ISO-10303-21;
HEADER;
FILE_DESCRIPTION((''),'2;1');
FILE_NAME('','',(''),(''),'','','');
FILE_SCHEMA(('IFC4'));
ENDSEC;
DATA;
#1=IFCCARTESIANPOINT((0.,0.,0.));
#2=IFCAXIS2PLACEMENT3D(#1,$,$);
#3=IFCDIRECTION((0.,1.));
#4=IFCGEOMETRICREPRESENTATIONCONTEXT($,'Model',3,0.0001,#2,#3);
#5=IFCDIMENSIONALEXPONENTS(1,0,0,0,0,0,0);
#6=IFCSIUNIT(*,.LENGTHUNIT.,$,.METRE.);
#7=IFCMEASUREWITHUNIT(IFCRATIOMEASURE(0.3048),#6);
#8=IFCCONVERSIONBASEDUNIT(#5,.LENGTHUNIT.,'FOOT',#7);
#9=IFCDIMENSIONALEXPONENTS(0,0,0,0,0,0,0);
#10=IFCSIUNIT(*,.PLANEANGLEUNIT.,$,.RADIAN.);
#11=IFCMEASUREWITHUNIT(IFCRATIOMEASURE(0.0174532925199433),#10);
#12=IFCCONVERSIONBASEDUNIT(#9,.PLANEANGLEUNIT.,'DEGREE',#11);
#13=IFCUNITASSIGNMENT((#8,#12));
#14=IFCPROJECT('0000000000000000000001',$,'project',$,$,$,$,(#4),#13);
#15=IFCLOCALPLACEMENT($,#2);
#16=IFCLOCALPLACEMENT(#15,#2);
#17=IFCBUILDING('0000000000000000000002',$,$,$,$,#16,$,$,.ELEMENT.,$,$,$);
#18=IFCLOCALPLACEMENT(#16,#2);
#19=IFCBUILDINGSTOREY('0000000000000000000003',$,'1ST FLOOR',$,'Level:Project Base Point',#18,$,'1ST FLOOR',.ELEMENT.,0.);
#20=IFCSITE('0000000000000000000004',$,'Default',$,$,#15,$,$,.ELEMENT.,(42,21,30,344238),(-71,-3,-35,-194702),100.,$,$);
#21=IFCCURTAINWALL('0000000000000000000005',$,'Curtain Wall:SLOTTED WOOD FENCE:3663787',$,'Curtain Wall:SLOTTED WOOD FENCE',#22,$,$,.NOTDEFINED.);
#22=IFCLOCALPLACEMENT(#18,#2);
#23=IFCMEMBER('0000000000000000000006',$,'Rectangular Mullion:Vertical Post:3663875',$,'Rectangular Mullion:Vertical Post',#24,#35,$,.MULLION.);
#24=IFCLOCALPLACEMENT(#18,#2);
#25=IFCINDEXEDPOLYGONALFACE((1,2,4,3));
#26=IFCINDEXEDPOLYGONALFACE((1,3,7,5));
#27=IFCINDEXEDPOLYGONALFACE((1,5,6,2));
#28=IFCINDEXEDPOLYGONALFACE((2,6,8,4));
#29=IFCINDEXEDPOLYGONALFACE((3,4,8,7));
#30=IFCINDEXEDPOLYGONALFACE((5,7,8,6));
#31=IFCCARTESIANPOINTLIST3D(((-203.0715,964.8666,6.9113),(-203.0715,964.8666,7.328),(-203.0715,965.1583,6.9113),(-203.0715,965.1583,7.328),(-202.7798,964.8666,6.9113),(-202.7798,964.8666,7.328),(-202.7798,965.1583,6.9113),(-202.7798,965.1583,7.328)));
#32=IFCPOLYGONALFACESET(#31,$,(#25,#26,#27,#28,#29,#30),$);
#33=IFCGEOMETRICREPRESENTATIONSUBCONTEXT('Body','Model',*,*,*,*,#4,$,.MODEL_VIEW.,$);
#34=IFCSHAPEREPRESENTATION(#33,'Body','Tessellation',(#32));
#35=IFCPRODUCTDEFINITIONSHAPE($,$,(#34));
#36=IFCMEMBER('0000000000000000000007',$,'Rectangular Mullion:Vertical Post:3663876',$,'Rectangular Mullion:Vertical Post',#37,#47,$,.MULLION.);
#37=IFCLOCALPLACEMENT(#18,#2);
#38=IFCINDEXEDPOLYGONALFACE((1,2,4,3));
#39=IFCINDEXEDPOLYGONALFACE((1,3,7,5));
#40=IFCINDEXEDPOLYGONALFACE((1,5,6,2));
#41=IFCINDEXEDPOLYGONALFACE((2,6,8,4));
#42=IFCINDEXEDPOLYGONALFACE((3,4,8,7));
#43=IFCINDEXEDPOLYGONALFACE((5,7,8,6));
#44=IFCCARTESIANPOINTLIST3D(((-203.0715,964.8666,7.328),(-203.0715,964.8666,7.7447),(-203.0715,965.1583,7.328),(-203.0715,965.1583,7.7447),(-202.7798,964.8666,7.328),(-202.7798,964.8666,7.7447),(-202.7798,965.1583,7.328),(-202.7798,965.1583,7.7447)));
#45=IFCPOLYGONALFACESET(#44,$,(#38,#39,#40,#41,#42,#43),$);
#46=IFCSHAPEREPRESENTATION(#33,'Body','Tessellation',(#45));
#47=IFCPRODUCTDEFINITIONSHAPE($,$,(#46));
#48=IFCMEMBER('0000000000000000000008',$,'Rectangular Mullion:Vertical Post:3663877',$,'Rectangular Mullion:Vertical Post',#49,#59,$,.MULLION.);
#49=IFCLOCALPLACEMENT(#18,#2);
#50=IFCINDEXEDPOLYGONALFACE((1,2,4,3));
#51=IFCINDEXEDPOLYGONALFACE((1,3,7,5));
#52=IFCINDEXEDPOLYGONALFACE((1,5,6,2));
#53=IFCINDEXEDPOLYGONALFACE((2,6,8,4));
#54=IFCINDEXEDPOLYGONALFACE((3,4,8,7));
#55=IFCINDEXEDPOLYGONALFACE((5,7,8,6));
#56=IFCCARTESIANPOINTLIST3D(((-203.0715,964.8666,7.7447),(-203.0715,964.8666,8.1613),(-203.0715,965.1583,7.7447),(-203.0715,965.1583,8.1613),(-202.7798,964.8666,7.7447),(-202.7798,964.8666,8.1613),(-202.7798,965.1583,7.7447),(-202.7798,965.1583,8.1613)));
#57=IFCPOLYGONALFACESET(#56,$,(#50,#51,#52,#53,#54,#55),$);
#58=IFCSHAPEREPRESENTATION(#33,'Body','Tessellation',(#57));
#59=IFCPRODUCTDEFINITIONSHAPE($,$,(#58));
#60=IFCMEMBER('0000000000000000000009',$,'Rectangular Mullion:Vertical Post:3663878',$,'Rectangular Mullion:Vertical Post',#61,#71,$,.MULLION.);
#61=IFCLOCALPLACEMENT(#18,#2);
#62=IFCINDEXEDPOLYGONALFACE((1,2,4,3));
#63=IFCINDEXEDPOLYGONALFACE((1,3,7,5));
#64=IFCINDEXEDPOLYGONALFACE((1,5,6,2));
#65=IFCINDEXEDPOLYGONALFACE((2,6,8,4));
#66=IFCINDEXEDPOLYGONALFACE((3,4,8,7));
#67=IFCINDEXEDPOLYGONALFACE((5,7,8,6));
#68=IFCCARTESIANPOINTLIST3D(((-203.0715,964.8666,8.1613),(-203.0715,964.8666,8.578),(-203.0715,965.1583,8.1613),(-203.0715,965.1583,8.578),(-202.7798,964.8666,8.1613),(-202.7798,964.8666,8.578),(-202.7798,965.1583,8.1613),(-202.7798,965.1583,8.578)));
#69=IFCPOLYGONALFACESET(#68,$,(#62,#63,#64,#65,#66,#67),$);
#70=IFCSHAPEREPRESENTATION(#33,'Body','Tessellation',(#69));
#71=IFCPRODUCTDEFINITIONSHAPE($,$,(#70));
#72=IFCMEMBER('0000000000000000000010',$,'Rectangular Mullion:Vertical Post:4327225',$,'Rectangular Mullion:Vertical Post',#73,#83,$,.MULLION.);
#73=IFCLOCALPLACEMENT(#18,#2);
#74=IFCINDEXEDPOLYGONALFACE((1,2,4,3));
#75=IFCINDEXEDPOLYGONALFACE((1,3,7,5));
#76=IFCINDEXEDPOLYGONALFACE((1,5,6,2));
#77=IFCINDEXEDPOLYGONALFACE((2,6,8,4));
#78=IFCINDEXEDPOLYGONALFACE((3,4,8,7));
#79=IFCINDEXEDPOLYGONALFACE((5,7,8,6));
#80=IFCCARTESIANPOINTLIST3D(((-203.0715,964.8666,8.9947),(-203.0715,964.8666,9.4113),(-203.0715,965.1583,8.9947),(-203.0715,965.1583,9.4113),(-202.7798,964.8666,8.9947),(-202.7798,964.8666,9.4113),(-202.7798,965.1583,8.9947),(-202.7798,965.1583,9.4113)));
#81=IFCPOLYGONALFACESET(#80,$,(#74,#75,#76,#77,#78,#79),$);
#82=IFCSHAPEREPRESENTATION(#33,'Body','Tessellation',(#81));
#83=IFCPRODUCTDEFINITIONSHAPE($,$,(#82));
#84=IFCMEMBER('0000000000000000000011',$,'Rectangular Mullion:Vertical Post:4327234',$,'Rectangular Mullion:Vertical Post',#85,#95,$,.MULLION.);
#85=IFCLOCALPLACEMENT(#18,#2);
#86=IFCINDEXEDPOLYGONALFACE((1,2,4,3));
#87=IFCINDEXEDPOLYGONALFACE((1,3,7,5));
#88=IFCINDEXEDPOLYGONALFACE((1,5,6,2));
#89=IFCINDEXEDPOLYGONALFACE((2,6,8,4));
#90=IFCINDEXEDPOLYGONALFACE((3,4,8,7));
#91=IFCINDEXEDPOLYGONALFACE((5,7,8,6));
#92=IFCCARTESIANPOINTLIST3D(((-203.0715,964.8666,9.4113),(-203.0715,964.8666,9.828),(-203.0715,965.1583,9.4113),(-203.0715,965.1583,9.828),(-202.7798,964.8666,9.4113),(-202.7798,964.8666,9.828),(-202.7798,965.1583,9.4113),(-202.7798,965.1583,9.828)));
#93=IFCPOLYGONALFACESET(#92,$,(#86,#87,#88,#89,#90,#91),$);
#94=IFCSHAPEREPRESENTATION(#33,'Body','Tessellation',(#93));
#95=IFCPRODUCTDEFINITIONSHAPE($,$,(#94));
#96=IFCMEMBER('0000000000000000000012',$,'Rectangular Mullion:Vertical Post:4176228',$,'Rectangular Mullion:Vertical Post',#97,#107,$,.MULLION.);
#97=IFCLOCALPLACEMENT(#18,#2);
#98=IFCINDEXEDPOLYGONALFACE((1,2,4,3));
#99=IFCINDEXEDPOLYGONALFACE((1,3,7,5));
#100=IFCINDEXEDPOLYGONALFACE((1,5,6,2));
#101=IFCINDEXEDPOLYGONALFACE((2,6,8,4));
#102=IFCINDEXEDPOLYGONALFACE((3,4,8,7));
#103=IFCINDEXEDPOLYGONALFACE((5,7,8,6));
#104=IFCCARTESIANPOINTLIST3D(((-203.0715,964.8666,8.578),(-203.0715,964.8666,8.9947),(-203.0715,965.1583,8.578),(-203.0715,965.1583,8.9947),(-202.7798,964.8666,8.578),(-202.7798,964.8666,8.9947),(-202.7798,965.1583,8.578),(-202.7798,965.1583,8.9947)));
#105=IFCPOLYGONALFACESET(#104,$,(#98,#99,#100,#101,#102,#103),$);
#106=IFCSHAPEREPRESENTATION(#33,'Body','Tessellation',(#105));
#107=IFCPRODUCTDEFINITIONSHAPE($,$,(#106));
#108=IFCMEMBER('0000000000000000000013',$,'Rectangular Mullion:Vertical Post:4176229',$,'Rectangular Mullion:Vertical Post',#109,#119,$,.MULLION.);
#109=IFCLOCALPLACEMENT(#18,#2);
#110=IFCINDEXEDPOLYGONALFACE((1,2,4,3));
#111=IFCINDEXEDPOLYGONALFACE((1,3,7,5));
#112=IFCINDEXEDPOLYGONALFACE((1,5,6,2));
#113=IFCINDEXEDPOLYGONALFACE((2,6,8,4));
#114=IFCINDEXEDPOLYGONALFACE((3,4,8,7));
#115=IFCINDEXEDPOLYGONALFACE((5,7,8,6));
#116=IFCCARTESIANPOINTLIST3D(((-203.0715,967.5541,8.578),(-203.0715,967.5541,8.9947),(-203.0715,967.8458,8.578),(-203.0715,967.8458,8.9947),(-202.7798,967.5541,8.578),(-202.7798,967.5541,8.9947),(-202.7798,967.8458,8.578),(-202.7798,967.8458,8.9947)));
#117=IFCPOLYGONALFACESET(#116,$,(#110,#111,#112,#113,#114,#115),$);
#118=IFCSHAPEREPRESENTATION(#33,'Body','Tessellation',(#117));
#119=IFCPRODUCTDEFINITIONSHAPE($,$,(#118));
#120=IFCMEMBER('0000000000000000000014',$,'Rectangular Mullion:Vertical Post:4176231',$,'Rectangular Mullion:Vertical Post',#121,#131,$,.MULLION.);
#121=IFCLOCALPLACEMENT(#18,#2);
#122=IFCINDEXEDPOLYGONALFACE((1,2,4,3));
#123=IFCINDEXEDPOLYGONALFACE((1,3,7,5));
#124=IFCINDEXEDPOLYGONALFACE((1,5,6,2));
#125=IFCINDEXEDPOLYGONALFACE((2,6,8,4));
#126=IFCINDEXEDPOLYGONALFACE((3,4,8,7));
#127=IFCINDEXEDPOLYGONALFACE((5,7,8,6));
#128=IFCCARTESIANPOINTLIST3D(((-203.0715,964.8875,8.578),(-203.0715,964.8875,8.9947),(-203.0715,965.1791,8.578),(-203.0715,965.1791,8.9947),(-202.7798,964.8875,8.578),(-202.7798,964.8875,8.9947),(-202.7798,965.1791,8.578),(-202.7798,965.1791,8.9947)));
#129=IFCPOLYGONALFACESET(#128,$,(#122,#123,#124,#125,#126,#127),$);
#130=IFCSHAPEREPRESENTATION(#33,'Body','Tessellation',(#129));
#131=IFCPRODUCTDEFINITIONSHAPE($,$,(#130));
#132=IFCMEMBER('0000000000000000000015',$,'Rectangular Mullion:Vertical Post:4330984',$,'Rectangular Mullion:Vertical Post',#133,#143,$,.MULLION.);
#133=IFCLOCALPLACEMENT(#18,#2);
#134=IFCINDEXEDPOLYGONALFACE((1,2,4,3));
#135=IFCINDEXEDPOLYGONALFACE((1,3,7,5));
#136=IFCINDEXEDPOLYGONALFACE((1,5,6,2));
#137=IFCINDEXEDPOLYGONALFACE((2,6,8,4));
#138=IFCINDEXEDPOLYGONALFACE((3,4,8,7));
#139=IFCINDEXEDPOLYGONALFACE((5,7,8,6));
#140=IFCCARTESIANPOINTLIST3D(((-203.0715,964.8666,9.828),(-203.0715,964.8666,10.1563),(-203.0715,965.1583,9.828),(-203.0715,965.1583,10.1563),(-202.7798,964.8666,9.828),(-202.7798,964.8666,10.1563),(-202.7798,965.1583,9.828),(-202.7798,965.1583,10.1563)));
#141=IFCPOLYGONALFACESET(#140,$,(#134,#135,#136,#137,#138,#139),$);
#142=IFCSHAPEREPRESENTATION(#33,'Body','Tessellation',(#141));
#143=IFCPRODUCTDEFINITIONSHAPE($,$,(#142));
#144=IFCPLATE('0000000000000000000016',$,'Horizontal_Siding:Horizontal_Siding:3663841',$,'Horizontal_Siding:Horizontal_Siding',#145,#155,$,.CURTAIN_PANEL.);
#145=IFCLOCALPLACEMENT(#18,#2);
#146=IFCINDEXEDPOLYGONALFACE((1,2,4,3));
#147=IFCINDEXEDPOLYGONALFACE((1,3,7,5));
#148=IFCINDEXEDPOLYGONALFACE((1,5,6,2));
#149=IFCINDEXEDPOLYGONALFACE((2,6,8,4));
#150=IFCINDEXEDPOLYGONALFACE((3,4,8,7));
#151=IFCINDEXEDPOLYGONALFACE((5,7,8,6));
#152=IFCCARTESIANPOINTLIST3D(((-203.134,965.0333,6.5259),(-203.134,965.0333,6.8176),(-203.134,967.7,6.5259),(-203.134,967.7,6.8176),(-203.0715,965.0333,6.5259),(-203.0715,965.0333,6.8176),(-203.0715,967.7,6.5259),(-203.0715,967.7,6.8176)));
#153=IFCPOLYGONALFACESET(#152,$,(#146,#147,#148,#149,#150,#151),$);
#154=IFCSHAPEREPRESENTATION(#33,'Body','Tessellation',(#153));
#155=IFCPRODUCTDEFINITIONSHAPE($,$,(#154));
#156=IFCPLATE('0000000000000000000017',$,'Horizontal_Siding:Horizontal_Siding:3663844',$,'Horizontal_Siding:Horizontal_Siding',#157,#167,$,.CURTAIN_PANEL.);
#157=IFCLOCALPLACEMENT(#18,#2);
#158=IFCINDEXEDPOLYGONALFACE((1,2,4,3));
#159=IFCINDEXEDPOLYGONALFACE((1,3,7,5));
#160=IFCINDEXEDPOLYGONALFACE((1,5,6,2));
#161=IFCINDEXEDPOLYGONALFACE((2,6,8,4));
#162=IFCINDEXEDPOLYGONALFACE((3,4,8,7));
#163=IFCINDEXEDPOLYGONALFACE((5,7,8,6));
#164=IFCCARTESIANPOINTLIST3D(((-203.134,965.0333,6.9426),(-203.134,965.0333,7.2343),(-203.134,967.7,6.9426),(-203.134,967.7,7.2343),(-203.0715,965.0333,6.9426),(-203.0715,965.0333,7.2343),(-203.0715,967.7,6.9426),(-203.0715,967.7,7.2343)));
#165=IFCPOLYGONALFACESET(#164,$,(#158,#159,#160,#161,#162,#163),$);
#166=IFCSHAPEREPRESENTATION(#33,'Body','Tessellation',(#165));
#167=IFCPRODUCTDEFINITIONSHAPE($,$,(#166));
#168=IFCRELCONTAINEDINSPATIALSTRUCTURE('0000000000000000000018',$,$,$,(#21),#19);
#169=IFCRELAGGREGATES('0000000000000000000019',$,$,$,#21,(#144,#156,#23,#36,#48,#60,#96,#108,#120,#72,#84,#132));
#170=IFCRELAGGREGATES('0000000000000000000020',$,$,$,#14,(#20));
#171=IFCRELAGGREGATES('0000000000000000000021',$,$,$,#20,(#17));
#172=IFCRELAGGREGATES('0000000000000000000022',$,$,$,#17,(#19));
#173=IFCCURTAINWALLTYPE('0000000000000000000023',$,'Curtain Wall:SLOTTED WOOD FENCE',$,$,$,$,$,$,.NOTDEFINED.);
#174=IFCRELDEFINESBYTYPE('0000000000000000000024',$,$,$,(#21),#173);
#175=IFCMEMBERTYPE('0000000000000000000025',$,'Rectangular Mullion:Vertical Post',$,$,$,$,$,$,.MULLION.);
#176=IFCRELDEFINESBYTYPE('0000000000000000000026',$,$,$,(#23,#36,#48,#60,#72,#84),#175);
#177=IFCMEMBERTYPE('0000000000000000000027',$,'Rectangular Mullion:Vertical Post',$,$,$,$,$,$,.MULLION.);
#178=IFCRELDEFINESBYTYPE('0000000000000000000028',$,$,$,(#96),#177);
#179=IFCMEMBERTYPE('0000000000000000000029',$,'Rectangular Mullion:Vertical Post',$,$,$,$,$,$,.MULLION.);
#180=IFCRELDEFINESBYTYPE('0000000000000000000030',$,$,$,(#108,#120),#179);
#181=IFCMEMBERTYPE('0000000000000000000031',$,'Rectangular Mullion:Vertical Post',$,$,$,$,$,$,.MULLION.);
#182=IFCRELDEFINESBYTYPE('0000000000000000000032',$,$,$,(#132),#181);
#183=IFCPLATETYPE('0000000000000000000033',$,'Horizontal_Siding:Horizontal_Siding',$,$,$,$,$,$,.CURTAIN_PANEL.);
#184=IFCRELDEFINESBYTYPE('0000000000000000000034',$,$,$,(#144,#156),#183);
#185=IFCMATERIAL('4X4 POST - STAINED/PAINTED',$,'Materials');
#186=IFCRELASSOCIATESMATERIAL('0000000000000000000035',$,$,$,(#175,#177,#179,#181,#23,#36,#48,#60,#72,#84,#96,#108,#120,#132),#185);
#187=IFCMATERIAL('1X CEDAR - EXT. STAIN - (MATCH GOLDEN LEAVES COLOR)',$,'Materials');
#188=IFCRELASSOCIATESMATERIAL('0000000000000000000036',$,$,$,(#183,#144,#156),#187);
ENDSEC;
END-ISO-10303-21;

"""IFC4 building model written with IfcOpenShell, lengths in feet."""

from ifc_helpers import new_model, entity, si_unit, converted_unit, direction, frame, origin, origin_2d_with_axis, place, context, subcontext, project, spatial, rectangle, extrude, source, transform, mapped, material, material_profile, profile_set, profile_usage, type_object, type_shapes, element, aggregate, save


model = new_model("IFC4")

# Units and contexts
model_context = context("Model", 3, precision=0.0001, world=origin(), true_north=direction((0.0, 1.0)))
body_context = subcontext(model_context, "Body", "Model", "MODEL_VIEW")
ifc_project = project(units=[converted_unit("LENGTHUNIT", "FOOT", entity("IfcRatioMeasure", 0.3048), si_unit("LENGTHUNIT", "METRE"), dimensions=[1, 0, 0, 0, 0, 0, 0]), converted_unit("PLANEANGLEUNIT", "DEGREE", entity("IfcRatioMeasure", 0.0174532925199433), si_unit("PLANEANGLEUNIT", "RADIAN"), dimensions=[0, 0, 0, 0, 0, 0, 0])], contexts=[model_context])

# Site, building, storey
site_placement = place(None, origin())
site = spatial("IfcSite", under=ifc_project, at=site_placement, Name="Default", CompositionType="ELEMENT", RefLatitude=(42, 21, 30, 344238), RefLongitude=(-71, -3, -35, -194702), RefElevation=100.0)
building_placement = place(site_placement, origin())
building = spatial("IfcBuilding", under=site, at=building_placement, CompositionType="ELEMENT")
storey_placement = place(building_placement, origin())
storey = spatial("IfcBuildingStorey", under=building, at=storey_placement, Name="1ST FLOOR", ObjectType="Level:Project Base Point", LongName="1ST FLOOR", CompositionType="ELEMENT", Elevation=0.0)

# Curtain wall, members, plates
curtain_wall_type = type_object("IfcCurtainWallType", Name="Curtain Wall:SLOTTED WOOD FENCE", PredefinedType="NOTDEFINED")
curtain_wall_placement = place(storey_placement, origin())
curtain_wall = element("IfcCurtainWall", 1, at=curtain_wall_placement, inside=storey, type_object=curtain_wall_type, Name="Curtain Wall:SLOTTED WOOD FENCE:3663787", ObjectType="Curtain Wall:SLOTTED WOOD FENCE", PredefinedType="NOTDEFINED")
ifc_material_1 = material(Name="4X4 POST - STAINED/PAINTED", Category="Materials")
ifc_material_profile = material_profile(ifc_material_1, rectangle(XDim=0.2917, YDim=0.2917, at=origin_2d_with_axis()), Name="Vertical Post")
ifc_profile_set = profile_set([ifc_material_profile], Name="Vertical Post")
ifc_profile_usage_1 = profile_usage(ifc_profile_set)
member_type_1 = type_object("IfcMemberType", Name="Rectangular Mullion:Vertical Post", PredefinedType="MULLION", material=ifc_profile_set)
shared_shape_1 = source(origin(), body_context, "Body", "SweptSolid", [
    extrude(rectangle(XDim=0.2917, YDim=0.2917, at=origin_2d_with_axis()), frame((-0.1458, -0.2083, -0.4167), z_axis=(0.0, 0.0, 1.0), x_axis=(0.0, -1.0, 0.0)), (0.0, 0.0, 1.0), 0.4167),
])
type_shapes(member_type_1, [shared_shape_1])
member_1_placement = place(storey_placement, frame((-203.134, 964.8666, 6.9113), z_axis=(0.0, 0.0, -1.0), x_axis=(0.0, -1.0, 0.0)))
member_1 = element("IfcMember", 2, at=member_1_placement, type_object=member_type_1, material=ifc_profile_usage_1, Name="Rectangular Mullion:Vertical Post:3663875", ObjectType="Rectangular Mullion:Vertical Post", PredefinedType="MULLION", context=body_context, shape_type="MappedRepresentation", body=[
    mapped(shared_shape_1, transform((0.0, 0.0, 0.0), scale=1.0)),
])
ifc_profile_usage_2 = profile_usage(ifc_profile_set)
member_2_placement = place(storey_placement, frame((-203.134, 964.8666, 7.328), z_axis=(0.0, 0.0, -1.0), x_axis=(0.0, -1.0, 0.0)))
member_2 = element("IfcMember", 3, at=member_2_placement, type_object=member_type_1, material=ifc_profile_usage_2, Name="Rectangular Mullion:Vertical Post:3663876", ObjectType="Rectangular Mullion:Vertical Post", PredefinedType="MULLION", context=body_context, shape_type="MappedRepresentation", body=[
    mapped(shared_shape_1, transform((0.0, 0.0, 0.0), scale=1.0)),
])
ifc_profile_usage_3 = profile_usage(ifc_profile_set)
member_3_placement = place(storey_placement, frame((-203.134, 964.8666, 7.7447), z_axis=(0.0, 0.0, -1.0), x_axis=(0.0, -1.0, 0.0)))
member_3 = element("IfcMember", 4, at=member_3_placement, type_object=member_type_1, material=ifc_profile_usage_3, Name="Rectangular Mullion:Vertical Post:3663877", ObjectType="Rectangular Mullion:Vertical Post", PredefinedType="MULLION", context=body_context, shape_type="MappedRepresentation", body=[
    mapped(shared_shape_1, transform((0.0, 0.0, 0.0), scale=1.0)),
])
ifc_profile_usage_4 = profile_usage(ifc_profile_set)
member_4_placement = place(storey_placement, frame((-203.134, 964.8666, 8.1613), z_axis=(0.0, 0.0, -1.0), x_axis=(0.0, -1.0, 0.0)))
member_4 = element("IfcMember", 5, at=member_4_placement, type_object=member_type_1, material=ifc_profile_usage_4, Name="Rectangular Mullion:Vertical Post:3663878", ObjectType="Rectangular Mullion:Vertical Post", PredefinedType="MULLION", context=body_context, shape_type="MappedRepresentation", body=[
    mapped(shared_shape_1, transform((0.0, 0.0, 0.0), scale=1.0)),
])
ifc_profile_usage_5 = profile_usage(ifc_profile_set)
member_5_placement = place(storey_placement, frame((-203.134, 964.8666, 8.9947), z_axis=(0.0, 0.0, -1.0), x_axis=(0.0, -1.0, 0.0)))
member_5 = element("IfcMember", 6, at=member_5_placement, type_object=member_type_1, material=ifc_profile_usage_5, Name="Rectangular Mullion:Vertical Post:4327225", ObjectType="Rectangular Mullion:Vertical Post", PredefinedType="MULLION", context=body_context, shape_type="MappedRepresentation", body=[
    mapped(shared_shape_1, transform((0.0, 0.0, 0.0), scale=1.0)),
])
ifc_profile_usage_6 = profile_usage(ifc_profile_set)
member_6_placement = place(storey_placement, frame((-203.134, 964.8666, 9.4113), z_axis=(0.0, 0.0, -1.0), x_axis=(0.0, -1.0, 0.0)))
member_6 = element("IfcMember", 7, at=member_6_placement, type_object=member_type_1, material=ifc_profile_usage_6, Name="Rectangular Mullion:Vertical Post:4327234", ObjectType="Rectangular Mullion:Vertical Post", PredefinedType="MULLION", context=body_context, shape_type="MappedRepresentation", body=[
    mapped(shared_shape_1, transform((0.0, 0.0, 0.0), scale=1.0)),
])
ifc_profile_usage_7 = profile_usage(ifc_profile_set)
member_type_2 = type_object("IfcMemberType", Name="Rectangular Mullion:Vertical Post", PredefinedType="MULLION", material=ifc_profile_set)
shared_shape_2 = source(origin(), body_context, "Body", "SweptSolid", [
    extrude(rectangle(XDim=0.2917, YDim=0.2917, at=origin_2d_with_axis()), frame((-0.1458, -0.2083, -0.4167), z_axis=(0.0, 0.0, 1.0), x_axis=(0.0, -1.0, 0.0)), (0.0, 0.0, 1.0), 0.4167),
])
type_shapes(member_type_2, [shared_shape_2])
member_7_placement = place(storey_placement, frame((-203.134, 964.8666, 8.578), z_axis=(0.0, 0.0, -1.0), x_axis=(0.0, -1.0, 0.0)))
member_7 = element("IfcMember", 8, at=member_7_placement, type_object=member_type_2, material=ifc_profile_usage_7, Name="Rectangular Mullion:Vertical Post:4176228", ObjectType="Rectangular Mullion:Vertical Post", PredefinedType="MULLION", context=body_context, shape_type="MappedRepresentation", body=[
    mapped(shared_shape_2, transform((0.0, 0.0, 0.0), scale=1.0)),
])
ifc_profile_usage_8 = profile_usage(ifc_profile_set)
member_type_3 = type_object("IfcMemberType", Name="Rectangular Mullion:Vertical Post", PredefinedType="MULLION", material=ifc_profile_set)
shared_shape_3 = source(origin(), body_context, "Body", "SweptSolid", [
    extrude(rectangle(XDim=0.2917, YDim=0.2917, at=origin_2d_with_axis()), frame((0.0, -0.2083, -0.4167), z_axis=(0.0, 0.0, 1.0), x_axis=(0.0, -1.0, 0.0)), (0.0, 0.0, 1.0), 0.4167),
])
type_shapes(member_type_3, [shared_shape_3])
member_8_placement = place(storey_placement, frame((-203.134, 967.7, 8.578), z_axis=(0.0, 0.0, -1.0), x_axis=(0.0, -1.0, 0.0)))
member_8 = element("IfcMember", 9, at=member_8_placement, type_object=member_type_3, material=ifc_profile_usage_8, Name="Rectangular Mullion:Vertical Post:4176229", ObjectType="Rectangular Mullion:Vertical Post", PredefinedType="MULLION", context=body_context, shape_type="MappedRepresentation", body=[
    mapped(shared_shape_3, transform((0.0, 0.0, 0.0), scale=1.0)),
])
ifc_profile_usage_9 = profile_usage(ifc_profile_set)
member_9_placement = place(storey_placement, frame((-203.134, 965.0333, 8.578), z_axis=(0.0, 0.0, -1.0), x_axis=(0.0, -1.0, 0.0)))
member_9 = element("IfcMember", 10, at=member_9_placement, type_object=member_type_3, material=ifc_profile_usage_9, Name="Rectangular Mullion:Vertical Post:4176231", ObjectType="Rectangular Mullion:Vertical Post", PredefinedType="MULLION", context=body_context, shape_type="MappedRepresentation", body=[
    mapped(shared_shape_3, transform((0.0, 0.0, 0.0), scale=1.0)),
])
ifc_profile_usage_10 = profile_usage(ifc_profile_set)
member_type_4 = type_object("IfcMemberType", Name="Rectangular Mullion:Vertical Post", PredefinedType="MULLION", material=ifc_profile_set)
shared_shape_4 = source(origin(), body_context, "Body", "SweptSolid", [
    extrude(rectangle(XDim=0.2917, YDim=0.2917, at=origin_2d_with_axis()), frame((-0.1458, -0.2083, -0.3282), z_axis=(0.0, 0.0, 1.0), x_axis=(0.0, -1.0, 0.0)), (0.0, 0.0, 1.0), 0.3282),
])
type_shapes(member_type_4, [shared_shape_4])
member_10_placement = place(storey_placement, frame((-203.134, 964.8666, 9.828), z_axis=(0.0, 0.0, -1.0), x_axis=(0.0, -1.0, 0.0)))
member_10 = element("IfcMember", 11, at=member_10_placement, type_object=member_type_4, material=ifc_profile_usage_10, Name="Rectangular Mullion:Vertical Post:4330984", ObjectType="Rectangular Mullion:Vertical Post", PredefinedType="MULLION", context=body_context, shape_type="MappedRepresentation", body=[
    mapped(shared_shape_4, transform((0.0, 0.0, 0.0), scale=1.0)),
])
ifc_material_2 = material(Name="1X CEDAR - EXT. STAIN - (MATCH GOLDEN LEAVES COLOR)", Category="Materials")
plate_type = type_object("IfcPlateType", Name="Horizontal_Siding:Horizontal_Siding", PredefinedType="CURTAIN_PANEL", material=ifc_material_2)
shared_shape_5 = source(origin(), body_context, "Body", "SweptSolid", [
    extrude(rectangle(XDim=2.6667, YDim=0.0625, at=origin_2d_with_axis()), frame((1.3333, 0.0312, 0.0), z_axis=(0.0, 0.0, 1.0), x_axis=(-1.0, 0.0, 0.0)), (0.0, 0.0, 1.0), 0.2917),
])
type_shapes(plate_type, [shared_shape_5])
plate_1_placement = place(curtain_wall_placement, frame((-203.134, 967.7, 6.5259), z_axis=(0.0, 0.0, 1.0), x_axis=(0.0, -1.0, 0.0)))
plate_1 = element("IfcPlate", 12, at=plate_1_placement, type_object=plate_type, material=ifc_material_2, Name="Horizontal_Siding:Horizontal_Siding:3663841", ObjectType="Horizontal_Siding:Horizontal_Siding", PredefinedType="CURTAIN_PANEL", context=body_context, shape_type="MappedRepresentation", body=[
    mapped(shared_shape_5, transform((0.0, 0.0, 0.0), scale=1.0)),
])
plate_2_placement = place(curtain_wall_placement, frame((-203.134, 967.7, 6.9426), z_axis=(0.0, 0.0, 1.0), x_axis=(0.0, -1.0, 0.0)))
plate_2 = element("IfcPlate", 13, at=plate_2_placement, type_object=plate_type, material=ifc_material_2, Name="Horizontal_Siding:Horizontal_Siding:3663844", ObjectType="Horizontal_Siding:Horizontal_Siding", PredefinedType="CURTAIN_PANEL", context=body_context, shape_type="MappedRepresentation", body=[
    mapped(shared_shape_5, transform((0.0, 0.0, 0.0), scale=1.0)),
])
aggregate(curtain_wall, [plate_1, plate_2, member_1, member_2, member_3, member_4, member_7, member_8, member_9, member_5, member_6, member_10])

save(model, "model.ifc")
